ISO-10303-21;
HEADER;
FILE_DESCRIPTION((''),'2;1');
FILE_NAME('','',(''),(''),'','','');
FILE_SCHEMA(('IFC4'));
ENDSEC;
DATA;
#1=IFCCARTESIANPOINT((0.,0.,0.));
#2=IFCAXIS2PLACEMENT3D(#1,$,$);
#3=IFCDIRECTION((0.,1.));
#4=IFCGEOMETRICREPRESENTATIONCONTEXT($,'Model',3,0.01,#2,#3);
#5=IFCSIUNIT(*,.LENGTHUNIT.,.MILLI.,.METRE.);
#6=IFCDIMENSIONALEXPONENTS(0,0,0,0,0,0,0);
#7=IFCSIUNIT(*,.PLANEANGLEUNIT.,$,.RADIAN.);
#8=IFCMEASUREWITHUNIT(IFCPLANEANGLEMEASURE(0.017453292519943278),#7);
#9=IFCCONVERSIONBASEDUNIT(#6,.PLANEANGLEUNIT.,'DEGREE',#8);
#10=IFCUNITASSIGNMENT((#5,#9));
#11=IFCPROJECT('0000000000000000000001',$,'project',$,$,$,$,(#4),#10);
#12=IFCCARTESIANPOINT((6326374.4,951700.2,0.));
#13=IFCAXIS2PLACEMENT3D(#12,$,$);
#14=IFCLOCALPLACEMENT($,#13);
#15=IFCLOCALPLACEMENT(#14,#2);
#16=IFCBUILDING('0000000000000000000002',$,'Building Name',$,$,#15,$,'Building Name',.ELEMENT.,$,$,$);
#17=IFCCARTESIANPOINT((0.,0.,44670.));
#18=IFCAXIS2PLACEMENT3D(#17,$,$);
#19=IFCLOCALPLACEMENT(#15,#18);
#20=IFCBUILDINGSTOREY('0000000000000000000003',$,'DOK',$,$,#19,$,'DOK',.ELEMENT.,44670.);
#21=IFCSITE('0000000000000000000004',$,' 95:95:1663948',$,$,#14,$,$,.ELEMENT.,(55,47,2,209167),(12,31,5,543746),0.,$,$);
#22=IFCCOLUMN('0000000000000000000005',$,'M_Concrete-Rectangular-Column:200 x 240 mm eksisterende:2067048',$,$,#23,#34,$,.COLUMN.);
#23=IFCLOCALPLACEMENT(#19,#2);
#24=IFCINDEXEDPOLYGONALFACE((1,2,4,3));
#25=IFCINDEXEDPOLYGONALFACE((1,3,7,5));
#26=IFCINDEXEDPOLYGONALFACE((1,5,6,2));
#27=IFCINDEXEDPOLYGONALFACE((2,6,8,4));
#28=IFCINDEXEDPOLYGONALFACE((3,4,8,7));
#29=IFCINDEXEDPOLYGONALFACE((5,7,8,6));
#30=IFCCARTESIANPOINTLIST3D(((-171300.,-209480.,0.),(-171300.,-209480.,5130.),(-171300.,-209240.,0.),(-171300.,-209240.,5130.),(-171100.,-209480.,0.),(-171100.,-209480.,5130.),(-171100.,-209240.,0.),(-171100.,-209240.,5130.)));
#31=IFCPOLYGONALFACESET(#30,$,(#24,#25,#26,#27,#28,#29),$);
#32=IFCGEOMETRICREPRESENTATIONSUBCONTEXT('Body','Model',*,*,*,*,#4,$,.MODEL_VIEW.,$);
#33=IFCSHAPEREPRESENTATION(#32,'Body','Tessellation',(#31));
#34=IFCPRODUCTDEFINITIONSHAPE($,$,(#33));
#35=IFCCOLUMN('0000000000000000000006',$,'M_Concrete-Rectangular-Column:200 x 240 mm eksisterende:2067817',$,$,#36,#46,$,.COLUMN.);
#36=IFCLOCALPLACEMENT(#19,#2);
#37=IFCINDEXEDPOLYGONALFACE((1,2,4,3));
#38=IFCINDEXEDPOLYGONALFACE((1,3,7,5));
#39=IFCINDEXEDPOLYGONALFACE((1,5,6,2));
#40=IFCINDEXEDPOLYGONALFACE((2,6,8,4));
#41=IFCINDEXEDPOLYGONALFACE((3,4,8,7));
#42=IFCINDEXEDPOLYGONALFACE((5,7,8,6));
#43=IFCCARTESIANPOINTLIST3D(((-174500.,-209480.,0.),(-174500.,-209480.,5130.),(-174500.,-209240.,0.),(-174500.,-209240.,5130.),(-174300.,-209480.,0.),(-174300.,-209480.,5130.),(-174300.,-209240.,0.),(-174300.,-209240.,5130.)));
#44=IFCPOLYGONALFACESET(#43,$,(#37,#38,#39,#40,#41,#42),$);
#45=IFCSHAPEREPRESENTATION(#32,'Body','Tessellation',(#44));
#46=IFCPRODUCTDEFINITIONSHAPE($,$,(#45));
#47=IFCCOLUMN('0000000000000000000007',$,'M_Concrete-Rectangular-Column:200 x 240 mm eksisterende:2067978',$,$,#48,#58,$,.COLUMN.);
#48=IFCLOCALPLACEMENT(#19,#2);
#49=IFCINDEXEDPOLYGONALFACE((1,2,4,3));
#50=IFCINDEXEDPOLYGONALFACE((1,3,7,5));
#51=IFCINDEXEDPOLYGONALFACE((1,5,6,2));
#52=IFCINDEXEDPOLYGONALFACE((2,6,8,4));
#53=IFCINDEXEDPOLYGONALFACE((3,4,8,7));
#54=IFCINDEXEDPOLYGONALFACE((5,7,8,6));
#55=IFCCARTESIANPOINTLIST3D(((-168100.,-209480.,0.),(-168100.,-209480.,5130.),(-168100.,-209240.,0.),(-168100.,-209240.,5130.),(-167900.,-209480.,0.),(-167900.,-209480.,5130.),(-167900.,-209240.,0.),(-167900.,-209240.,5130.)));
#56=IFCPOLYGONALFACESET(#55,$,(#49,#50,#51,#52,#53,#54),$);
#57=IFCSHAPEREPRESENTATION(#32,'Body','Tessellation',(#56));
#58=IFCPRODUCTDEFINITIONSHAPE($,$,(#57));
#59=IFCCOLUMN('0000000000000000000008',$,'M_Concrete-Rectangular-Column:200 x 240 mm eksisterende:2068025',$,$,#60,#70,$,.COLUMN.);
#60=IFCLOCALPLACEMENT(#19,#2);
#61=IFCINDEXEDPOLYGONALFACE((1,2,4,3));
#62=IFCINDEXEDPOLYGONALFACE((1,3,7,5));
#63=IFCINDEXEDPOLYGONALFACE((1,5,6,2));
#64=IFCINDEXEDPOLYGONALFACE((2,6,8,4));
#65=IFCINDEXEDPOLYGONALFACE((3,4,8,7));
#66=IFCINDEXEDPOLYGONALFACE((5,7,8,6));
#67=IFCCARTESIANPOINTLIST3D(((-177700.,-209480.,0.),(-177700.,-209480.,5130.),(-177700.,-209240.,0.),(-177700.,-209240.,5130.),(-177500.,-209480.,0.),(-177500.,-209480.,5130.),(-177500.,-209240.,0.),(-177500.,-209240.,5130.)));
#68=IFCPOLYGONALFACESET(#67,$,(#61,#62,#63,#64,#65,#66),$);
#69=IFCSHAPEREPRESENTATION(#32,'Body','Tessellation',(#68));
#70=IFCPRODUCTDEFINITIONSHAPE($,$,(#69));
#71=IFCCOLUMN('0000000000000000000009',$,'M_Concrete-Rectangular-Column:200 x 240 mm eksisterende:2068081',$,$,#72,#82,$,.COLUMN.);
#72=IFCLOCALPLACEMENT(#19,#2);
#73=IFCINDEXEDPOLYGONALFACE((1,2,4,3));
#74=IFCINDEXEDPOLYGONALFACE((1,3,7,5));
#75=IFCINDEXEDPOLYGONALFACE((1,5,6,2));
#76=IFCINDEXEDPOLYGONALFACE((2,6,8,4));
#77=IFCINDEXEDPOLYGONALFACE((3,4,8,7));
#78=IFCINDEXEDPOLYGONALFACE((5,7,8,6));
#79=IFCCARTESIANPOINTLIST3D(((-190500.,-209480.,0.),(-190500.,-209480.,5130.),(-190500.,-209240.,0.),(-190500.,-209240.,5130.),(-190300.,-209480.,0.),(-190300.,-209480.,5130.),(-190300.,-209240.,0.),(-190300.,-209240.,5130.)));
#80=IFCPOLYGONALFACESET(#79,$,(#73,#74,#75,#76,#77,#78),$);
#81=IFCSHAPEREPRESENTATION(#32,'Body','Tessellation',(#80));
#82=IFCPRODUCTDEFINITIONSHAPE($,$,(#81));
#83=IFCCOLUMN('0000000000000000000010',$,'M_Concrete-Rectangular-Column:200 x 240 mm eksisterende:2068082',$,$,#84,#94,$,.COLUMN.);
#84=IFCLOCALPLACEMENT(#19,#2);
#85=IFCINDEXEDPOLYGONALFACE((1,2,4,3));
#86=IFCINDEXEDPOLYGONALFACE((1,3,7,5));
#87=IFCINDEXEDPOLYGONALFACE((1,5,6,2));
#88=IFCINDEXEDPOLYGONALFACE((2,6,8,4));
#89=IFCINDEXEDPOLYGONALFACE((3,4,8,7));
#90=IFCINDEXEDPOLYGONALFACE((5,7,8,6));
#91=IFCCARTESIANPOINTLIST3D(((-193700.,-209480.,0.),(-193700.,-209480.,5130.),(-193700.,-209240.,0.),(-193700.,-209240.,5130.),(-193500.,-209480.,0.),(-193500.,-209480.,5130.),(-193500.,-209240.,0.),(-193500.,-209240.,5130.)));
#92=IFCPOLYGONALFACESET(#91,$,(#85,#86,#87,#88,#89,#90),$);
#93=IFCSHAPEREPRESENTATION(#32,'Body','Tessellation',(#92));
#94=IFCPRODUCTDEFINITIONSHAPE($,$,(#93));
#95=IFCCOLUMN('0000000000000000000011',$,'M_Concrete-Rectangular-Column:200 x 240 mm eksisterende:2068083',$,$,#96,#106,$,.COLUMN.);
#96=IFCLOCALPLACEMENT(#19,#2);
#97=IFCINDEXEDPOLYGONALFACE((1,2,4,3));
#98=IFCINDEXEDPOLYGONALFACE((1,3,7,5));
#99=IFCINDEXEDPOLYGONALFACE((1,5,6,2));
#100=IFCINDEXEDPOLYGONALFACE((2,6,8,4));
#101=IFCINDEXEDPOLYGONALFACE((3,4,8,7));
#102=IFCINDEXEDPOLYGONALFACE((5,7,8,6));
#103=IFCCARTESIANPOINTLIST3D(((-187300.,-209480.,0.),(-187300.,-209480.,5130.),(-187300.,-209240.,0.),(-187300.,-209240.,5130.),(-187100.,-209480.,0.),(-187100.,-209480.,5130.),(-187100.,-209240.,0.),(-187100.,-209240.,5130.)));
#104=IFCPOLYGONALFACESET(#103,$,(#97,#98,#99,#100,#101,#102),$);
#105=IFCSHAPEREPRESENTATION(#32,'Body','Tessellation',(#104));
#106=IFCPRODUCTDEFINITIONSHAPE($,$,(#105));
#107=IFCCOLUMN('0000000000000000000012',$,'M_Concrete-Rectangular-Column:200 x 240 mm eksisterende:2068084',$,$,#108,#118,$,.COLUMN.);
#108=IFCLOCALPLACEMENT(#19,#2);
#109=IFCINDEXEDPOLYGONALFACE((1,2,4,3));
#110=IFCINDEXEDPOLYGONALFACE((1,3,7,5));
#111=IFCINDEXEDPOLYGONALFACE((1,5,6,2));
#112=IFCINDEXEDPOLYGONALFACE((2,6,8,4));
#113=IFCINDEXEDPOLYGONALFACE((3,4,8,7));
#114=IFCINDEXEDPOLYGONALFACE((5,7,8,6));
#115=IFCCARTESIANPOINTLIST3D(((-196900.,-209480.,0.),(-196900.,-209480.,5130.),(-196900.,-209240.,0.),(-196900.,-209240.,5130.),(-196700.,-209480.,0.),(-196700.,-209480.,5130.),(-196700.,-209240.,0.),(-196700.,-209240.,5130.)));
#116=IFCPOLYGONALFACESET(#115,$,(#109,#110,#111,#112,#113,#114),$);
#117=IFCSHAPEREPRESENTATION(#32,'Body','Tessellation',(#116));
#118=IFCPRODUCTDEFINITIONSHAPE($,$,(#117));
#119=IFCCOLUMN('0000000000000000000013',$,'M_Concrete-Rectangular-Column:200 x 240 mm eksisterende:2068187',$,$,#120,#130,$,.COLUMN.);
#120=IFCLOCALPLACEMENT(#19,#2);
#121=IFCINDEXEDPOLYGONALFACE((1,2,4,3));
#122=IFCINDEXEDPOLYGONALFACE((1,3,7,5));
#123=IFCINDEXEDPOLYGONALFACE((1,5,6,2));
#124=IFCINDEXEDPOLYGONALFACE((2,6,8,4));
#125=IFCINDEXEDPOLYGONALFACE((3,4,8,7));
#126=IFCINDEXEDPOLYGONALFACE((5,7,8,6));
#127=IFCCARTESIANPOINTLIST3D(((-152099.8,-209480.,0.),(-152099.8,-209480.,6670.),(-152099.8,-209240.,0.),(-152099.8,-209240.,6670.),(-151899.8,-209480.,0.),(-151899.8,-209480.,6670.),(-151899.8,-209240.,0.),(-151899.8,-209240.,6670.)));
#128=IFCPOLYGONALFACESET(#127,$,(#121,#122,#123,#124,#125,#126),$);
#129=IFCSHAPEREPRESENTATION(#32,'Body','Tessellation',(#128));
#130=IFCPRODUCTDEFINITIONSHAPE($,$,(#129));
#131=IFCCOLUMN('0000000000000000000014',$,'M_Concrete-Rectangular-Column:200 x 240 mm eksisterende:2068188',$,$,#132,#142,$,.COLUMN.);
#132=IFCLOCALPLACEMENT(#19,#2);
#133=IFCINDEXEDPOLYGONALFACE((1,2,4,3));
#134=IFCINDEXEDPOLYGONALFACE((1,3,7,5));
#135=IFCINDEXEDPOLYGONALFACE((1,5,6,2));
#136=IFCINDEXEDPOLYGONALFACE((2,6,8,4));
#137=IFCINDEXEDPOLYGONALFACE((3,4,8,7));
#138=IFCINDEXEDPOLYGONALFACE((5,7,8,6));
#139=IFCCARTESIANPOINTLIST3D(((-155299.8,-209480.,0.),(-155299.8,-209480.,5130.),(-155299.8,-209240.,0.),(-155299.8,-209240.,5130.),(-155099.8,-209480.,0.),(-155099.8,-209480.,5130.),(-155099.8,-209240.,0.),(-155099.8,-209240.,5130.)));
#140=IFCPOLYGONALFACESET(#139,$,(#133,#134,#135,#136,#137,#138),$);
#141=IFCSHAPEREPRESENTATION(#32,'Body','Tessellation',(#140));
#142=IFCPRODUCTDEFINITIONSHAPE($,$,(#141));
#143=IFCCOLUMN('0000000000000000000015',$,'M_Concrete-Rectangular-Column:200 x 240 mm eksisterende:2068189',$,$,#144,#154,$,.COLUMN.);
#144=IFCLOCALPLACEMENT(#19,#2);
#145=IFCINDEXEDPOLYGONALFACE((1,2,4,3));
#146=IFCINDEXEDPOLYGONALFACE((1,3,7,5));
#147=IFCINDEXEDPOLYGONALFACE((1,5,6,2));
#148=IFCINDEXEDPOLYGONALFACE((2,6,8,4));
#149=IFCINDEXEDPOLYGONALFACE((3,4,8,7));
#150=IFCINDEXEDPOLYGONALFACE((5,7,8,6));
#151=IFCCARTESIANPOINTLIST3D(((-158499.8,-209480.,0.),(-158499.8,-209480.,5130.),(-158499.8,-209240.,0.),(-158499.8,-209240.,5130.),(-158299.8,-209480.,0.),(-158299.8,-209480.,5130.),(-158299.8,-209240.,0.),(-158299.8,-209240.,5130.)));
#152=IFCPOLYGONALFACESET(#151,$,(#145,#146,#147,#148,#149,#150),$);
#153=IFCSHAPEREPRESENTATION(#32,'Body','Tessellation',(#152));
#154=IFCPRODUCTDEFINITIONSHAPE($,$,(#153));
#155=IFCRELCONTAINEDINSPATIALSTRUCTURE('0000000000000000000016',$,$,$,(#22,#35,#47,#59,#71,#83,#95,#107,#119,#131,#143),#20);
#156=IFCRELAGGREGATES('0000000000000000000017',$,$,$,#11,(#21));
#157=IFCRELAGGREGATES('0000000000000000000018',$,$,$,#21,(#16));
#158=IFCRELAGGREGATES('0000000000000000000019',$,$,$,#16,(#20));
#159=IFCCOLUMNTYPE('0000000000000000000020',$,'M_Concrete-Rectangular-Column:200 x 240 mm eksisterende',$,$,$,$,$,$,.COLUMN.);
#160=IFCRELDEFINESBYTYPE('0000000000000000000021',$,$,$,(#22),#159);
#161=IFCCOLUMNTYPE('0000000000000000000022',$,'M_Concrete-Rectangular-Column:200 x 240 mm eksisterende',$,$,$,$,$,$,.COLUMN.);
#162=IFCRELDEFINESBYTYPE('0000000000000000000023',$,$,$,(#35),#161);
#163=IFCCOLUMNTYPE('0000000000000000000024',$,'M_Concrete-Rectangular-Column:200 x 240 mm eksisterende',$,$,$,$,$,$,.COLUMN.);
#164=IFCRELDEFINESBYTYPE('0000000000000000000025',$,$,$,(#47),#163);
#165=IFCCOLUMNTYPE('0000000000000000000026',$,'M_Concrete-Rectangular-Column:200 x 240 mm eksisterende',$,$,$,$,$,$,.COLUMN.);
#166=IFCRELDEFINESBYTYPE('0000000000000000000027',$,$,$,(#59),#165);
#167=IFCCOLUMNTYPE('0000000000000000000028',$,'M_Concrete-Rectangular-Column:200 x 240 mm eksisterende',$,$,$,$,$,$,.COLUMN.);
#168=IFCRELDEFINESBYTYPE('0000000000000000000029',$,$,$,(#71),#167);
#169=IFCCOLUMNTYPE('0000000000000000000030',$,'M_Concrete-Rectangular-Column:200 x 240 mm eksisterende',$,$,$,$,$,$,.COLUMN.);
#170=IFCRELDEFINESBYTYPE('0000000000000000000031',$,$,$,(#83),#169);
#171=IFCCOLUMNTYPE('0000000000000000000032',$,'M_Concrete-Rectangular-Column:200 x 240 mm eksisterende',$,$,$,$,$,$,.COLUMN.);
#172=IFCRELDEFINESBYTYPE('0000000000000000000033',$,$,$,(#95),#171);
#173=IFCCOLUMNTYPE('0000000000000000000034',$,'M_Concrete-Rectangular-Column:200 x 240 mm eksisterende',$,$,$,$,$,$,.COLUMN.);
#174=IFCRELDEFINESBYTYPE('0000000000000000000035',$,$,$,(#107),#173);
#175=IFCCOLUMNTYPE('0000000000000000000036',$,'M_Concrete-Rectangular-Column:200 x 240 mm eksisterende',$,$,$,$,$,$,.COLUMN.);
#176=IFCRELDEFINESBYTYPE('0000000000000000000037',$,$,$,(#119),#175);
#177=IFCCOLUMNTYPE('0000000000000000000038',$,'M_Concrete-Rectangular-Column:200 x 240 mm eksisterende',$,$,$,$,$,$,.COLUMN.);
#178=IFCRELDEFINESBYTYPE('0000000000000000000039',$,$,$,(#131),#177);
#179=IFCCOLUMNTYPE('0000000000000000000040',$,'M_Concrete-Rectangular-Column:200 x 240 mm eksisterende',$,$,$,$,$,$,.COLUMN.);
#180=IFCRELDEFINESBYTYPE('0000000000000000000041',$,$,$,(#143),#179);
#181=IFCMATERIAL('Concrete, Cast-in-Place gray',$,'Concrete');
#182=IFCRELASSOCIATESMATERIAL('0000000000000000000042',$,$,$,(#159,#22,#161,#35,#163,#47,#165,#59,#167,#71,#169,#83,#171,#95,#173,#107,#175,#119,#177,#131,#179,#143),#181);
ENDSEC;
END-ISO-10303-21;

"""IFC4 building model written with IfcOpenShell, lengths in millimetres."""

from ifc_helpers import new_model, entity, si_unit, converted_unit, direction, frame, origin, place, context, subcontext, project, spatial, indexed_curve, outline, extrude, source, transform, mapped, material, type_object, type_shapes, element, save


model = new_model("IFC4")

# Units and contexts
model_context = context("Model", 3, precision=0.01, world=origin(), true_north=direction((0.0, 1.0)))
body_context = subcontext(model_context, "Body", "Model", "MODEL_VIEW")
ifc_project = project(units=[si_unit("LENGTHUNIT", "METRE", prefix="MILLI"), converted_unit("PLANEANGLEUNIT", "DEGREE", entity("IfcPlaneAngleMeasure", 0.017453292519943278), si_unit("PLANEANGLEUNIT", "RADIAN"), dimensions=[0, 0, 0, 0, 0, 0, 0])], contexts=[model_context])

# Site, building, storey
site_placement = place(None, frame((6326374.4, 951700.2, 0.0)))
site = spatial("IfcSite", under=ifc_project, at=site_placement, Name=" 95:95:1663948", CompositionType="ELEMENT", RefLatitude=(55, 47, 2, 209167), RefLongitude=(12, 31, 5, 543746), RefElevation=0.0)
building_placement = place(site_placement, origin())
building = spatial("IfcBuilding", under=site, at=building_placement, Name="Building Name", LongName="Building Name", CompositionType="ELEMENT")
storey_placement = place(building_placement, frame((0.0, 0.0, 44670.0)))
storey = spatial("IfcBuildingStorey", under=building, at=storey_placement, Name="DOK", LongName="DOK", CompositionType="ELEMENT", Elevation=44670.0)

# Columns
ifc_material_1 = material(Name="Concrete, Cast-in-Place gray", Category="Concrete")
column_type_1 = type_object("IfcColumnType", Name="M_Concrete-Rectangular-Column:200 x 240 mm eksisterende", PredefinedType="COLUMN", material=ifc_material_1)
shared_shape_1 = source(origin(), body_context, "Body", "SweptSolid", [
    extrude(outline(indexed_curve([(-100.0, -120.0), (100.0, -120.0), (100.0, 120.0), (-100.0, 120.0), (-100.0, -120.0)], self_intersect=False)), frame((-171200.0, -209360.0, 44670.0), z_axis=(0.0, 0.0, 1.0), x_axis=(-1.0, 0.0, 0.0)), (0.0, 0.0, 1.0), 5130.0),
])
type_shapes(column_type_1, [shared_shape_1])
column_1_placement = place(storey_placement, frame((0.0, 0.0, -44670.0)))
element("IfcColumn", 1, at=column_1_placement, inside=storey, type_object=column_type_1, material=ifc_material_1, Name="M_Concrete-Rectangular-Column:200 x 240 mm eksisterende:2067048", PredefinedType="COLUMN", context=body_context, shape_type="MappedRepresentation", body=[
    mapped(shared_shape_1, transform((0.0, 0.0, 0.0), scale=1.0)),
])
column_type_2 = type_object("IfcColumnType", Name="M_Concrete-Rectangular-Column:200 x 240 mm eksisterende", PredefinedType="COLUMN", material=ifc_material_1)
shared_shape_2 = source(origin(), body_context, "Body", "SweptSolid", [
    extrude(outline(indexed_curve([(-100.0, -120.0), (100.0, -120.0), (100.0, 120.0), (-100.0, 120.0), (-100.0, -120.0)], self_intersect=False)), frame((-174400.0, -209360.0, 44670.0), z_axis=(0.0, 0.0, 1.0), x_axis=(-1.0, 0.0, 0.0)), (0.0, 0.0, 1.0), 5130.0),
])
type_shapes(column_type_2, [shared_shape_2])
column_2_placement = place(storey_placement, frame((0.0, 0.0, -44670.0)))
element("IfcColumn", 2, at=column_2_placement, inside=storey, type_object=column_type_2, material=ifc_material_1, Name="M_Concrete-Rectangular-Column:200 x 240 mm eksisterende:2067817", PredefinedType="COLUMN", context=body_context, shape_type="MappedRepresentation", body=[
    mapped(shared_shape_2, transform((0.0, 0.0, 0.0), scale=1.0)),
])
column_type_3 = type_object("IfcColumnType", Name="M_Concrete-Rectangular-Column:200 x 240 mm eksisterende", PredefinedType="COLUMN", material=ifc_material_1)
shared_shape_3 = source(origin(), body_context, "Body", "SweptSolid", [
    extrude(outline(indexed_curve([(-100.0, -120.0), (100.0, -120.0), (100.0, 120.0), (-100.0, 120.0), (-100.0, -120.0)], self_intersect=False)), frame((-168000.0, -209360.0, 44670.0), z_axis=(0.0, 0.0, 1.0), x_axis=(-1.0, 0.0, 0.0)), (0.0, 0.0, 1.0), 5130.0),
])
type_shapes(column_type_3, [shared_shape_3])
column_3_placement = place(storey_placement, frame((0.0, 0.0, -44670.0)))
element("IfcColumn", 3, at=column_3_placement, inside=storey, type_object=column_type_3, material=ifc_material_1, Name="M_Concrete-Rectangular-Column:200 x 240 mm eksisterende:2067978", PredefinedType="COLUMN", context=body_context, shape_type="MappedRepresentation", body=[
    mapped(shared_shape_3, transform((0.0, 0.0, 0.0), scale=1.0)),
])
column_type_4 = type_object("IfcColumnType", Name="M_Concrete-Rectangular-Column:200 x 240 mm eksisterende", PredefinedType="COLUMN", material=ifc_material_1)
shared_shape_4 = source(origin(), body_context, "Body", "SweptSolid", [
    extrude(outline(indexed_curve([(-100.0, -120.0), (100.0, -120.0), (100.0, 120.0), (-100.0, 120.0), (-100.0, -120.0)], self_intersect=False)), frame((-177600.0, -209360.0, 44670.0), z_axis=(0.0, 0.0, 1.0), x_axis=(-1.0, 0.0, 0.0)), (0.0, 0.0, 1.0), 5130.0),
])
type_shapes(column_type_4, [shared_shape_4])
column_4_placement = place(storey_placement, frame((0.0, 0.0, -44670.0)))
element("IfcColumn", 4, at=column_4_placement, inside=storey, type_object=column_type_4, material=ifc_material_1, Name="M_Concrete-Rectangular-Column:200 x 240 mm eksisterende:2068025", PredefinedType="COLUMN", context=body_context, shape_type="MappedRepresentation", body=[
    mapped(shared_shape_4, transform((0.0, 0.0, 0.0), scale=1.0)),
])
column_type_5 = type_object("IfcColumnType", Name="M_Concrete-Rectangular-Column:200 x 240 mm eksisterende", PredefinedType="COLUMN", material=ifc_material_1)
shared_shape_5 = source(origin(), body_context, "Body", "SweptSolid", [
    extrude(outline(indexed_curve([(-100.0, -120.0), (100.0, -120.0), (100.0, 120.0), (-100.0, 120.0), (-100.0, -120.0)], self_intersect=False)), frame((-190400.0, -209360.0, 44670.0), z_axis=(0.0, 0.0, 1.0), x_axis=(-1.0, 0.0, 0.0)), (0.0, 0.0, 1.0), 5130.0),
])
type_shapes(column_type_5, [shared_shape_5])
column_5_placement = place(storey_placement, frame((0.0, 0.0, -44670.0)))
element("IfcColumn", 5, at=column_5_placement, inside=storey, type_object=column_type_5, material=ifc_material_1, Name="M_Concrete-Rectangular-Column:200 x 240 mm eksisterende:2068081", PredefinedType="COLUMN", context=body_context, shape_type="MappedRepresentation", body=[
    mapped(shared_shape_5, transform((0.0, 0.0, 0.0), scale=1.0)),
])
column_type_6 = type_object("IfcColumnType", Name="M_Concrete-Rectangular-Column:200 x 240 mm eksisterende", PredefinedType="COLUMN", material=ifc_material_1)
shared_shape_6 = source(origin(), body_context, "Body", "SweptSolid", [
    extrude(outline(indexed_curve([(-100.0, -120.0), (100.0, -120.0), (100.0, 120.0), (-100.0, 120.0), (-100.0, -120.0)], self_intersect=False)), frame((-193600.0, -209360.0, 44670.0), z_axis=(0.0, 0.0, 1.0), x_axis=(-1.0, 0.0, 0.0)), (0.0, 0.0, 1.0), 5130.0),
])
type_shapes(column_type_6, [shared_shape_6])
column_6_placement = place(storey_placement, frame((0.0, 0.0, -44670.0)))
element("IfcColumn", 6, at=column_6_placement, inside=storey, type_object=column_type_6, material=ifc_material_1, Name="M_Concrete-Rectangular-Column:200 x 240 mm eksisterende:2068082", PredefinedType="COLUMN", context=body_context, shape_type="MappedRepresentation", body=[
    mapped(shared_shape_6, transform((0.0, 0.0, 0.0), scale=1.0)),
])
column_type_7 = type_object("IfcColumnType", Name="M_Concrete-Rectangular-Column:200 x 240 mm eksisterende", PredefinedType="COLUMN", material=ifc_material_1)
shared_shape_7 = source(origin(), body_context, "Body", "SweptSolid", [
    extrude(outline(indexed_curve([(-100.0, -120.0), (100.0, -120.0), (100.0, 120.0), (-100.0, 120.0), (-100.0, -120.0)], self_intersect=False)), frame((-187200.0, -209360.0, 44670.0), z_axis=(0.0, 0.0, 1.0), x_axis=(-1.0, 0.0, 0.0)), (0.0, 0.0, 1.0), 5130.0),
])
type_shapes(column_type_7, [shared_shape_7])
column_7_placement = place(storey_placement, frame((0.0, 0.0, -44670.0)))
element("IfcColumn", 7, at=column_7_placement, inside=storey, type_object=column_type_7, material=ifc_material_1, Name="M_Concrete-Rectangular-Column:200 x 240 mm eksisterende:2068083", PredefinedType="COLUMN", context=body_context, shape_type="MappedRepresentation", body=[
    mapped(shared_shape_7, transform((0.0, 0.0, 0.0), scale=1.0)),
])
column_type_8 = type_object("IfcColumnType", Name="M_Concrete-Rectangular-Column:200 x 240 mm eksisterende", PredefinedType="COLUMN", material=ifc_material_1)
shared_shape_8 = source(origin(), body_context, "Body", "SweptSolid", [
    extrude(outline(indexed_curve([(-100.0, -120.0), (100.0, -120.0), (100.0, 120.0), (-100.0, 120.0), (-100.0, -120.0)], self_intersect=False)), frame((-196800.0, -209360.0, 44670.0), z_axis=(0.0, 0.0, 1.0), x_axis=(-1.0, 0.0, 0.0)), (0.0, 0.0, 1.0), 5130.0),
])
type_shapes(column_type_8, [shared_shape_8])
column_8_placement = place(storey_placement, frame((0.0, 0.0, -44670.0)))
element("IfcColumn", 8, at=column_8_placement, inside=storey, type_object=column_type_8, material=ifc_material_1, Name="M_Concrete-Rectangular-Column:200 x 240 mm eksisterende:2068084", PredefinedType="COLUMN", context=body_context, shape_type="MappedRepresentation", body=[
    mapped(shared_shape_8, transform((0.0, 0.0, 0.0), scale=1.0)),
])
column_type_9 = type_object("IfcColumnType", Name="M_Concrete-Rectangular-Column:200 x 240 mm eksisterende", PredefinedType="COLUMN", material=ifc_material_1)
shared_shape_9 = source(origin(), body_context, "Body", "SweptSolid", [
    extrude(outline(indexed_curve([(-100.0, -120.0), (100.0, -120.0), (100.0, 120.0), (-100.0, 120.0), (-100.0, -120.0)], self_intersect=False)), frame((-151999.8, -209360.0, 44670.0), z_axis=(0.0, 0.0, 1.0), x_axis=(-1.0, 0.0, 0.0)), (0.0, 0.0, 1.0), 6670.0),
])
type_shapes(column_type_9, [shared_shape_9])
column_9_placement = place(storey_placement, frame((0.0, 0.0, -44670.0)))
element("IfcColumn", 9, at=column_9_placement, inside=storey, type_object=column_type_9, material=ifc_material_1, Name="M_Concrete-Rectangular-Column:200 x 240 mm eksisterende:2068187", PredefinedType="COLUMN", context=body_context, shape_type="MappedRepresentation", body=[
    mapped(shared_shape_9, transform((0.0, 0.0, 0.0), scale=1.0)),
])
column_type_10 = type_object("IfcColumnType", Name="M_Concrete-Rectangular-Column:200 x 240 mm eksisterende", PredefinedType="COLUMN", material=ifc_material_1)
shared_shape_10 = source(origin(), body_context, "Body", "SweptSolid", [
    extrude(outline(indexed_curve([(-100.0, -120.0), (100.0, -120.0), (100.0, 120.0), (-100.0, 120.0), (-100.0, -120.0)], self_intersect=False)), frame((-155199.8, -209360.0, 44670.0), z_axis=(0.0, 0.0, 1.0), x_axis=(-1.0, 0.0, 0.0)), (0.0, 0.0, 1.0), 5130.0),
])
type_shapes(column_type_10, [shared_shape_10])
column_10_placement = place(storey_placement, frame((0.0, 0.0, -44670.0)))
element("IfcColumn", 10, at=column_10_placement, inside=storey, type_object=column_type_10, material=ifc_material_1, Name="M_Concrete-Rectangular-Column:200 x 240 mm eksisterende:2068188", PredefinedType="COLUMN", context=body_context, shape_type="MappedRepresentation", body=[
    mapped(shared_shape_10, transform((0.0, 0.0, 0.0), scale=1.0)),
])
column_type_11 = type_object("IfcColumnType", Name="M_Concrete-Rectangular-Column:200 x 240 mm eksisterende", PredefinedType="COLUMN", material=ifc_material_1)
shared_shape_11 = source(origin(), body_context, "Body", "SweptSolid", [
    extrude(outline(indexed_curve([(-100.0, -120.0), (100.0, -120.0), (100.0, 120.0), (-100.0, 120.0), (-100.0, -120.0)], self_intersect=False)), frame((-158399.8, -209360.0, 44670.0), z_axis=(0.0, 0.0, 1.0), x_axis=(-1.0, 0.0, 0.0)), (0.0, 0.0, 1.0), 5130.0),
])
type_shapes(column_type_11, [shared_shape_11])
column_11_placement = place(storey_placement, frame((0.0, 0.0, -44670.0)))
element("IfcColumn", 11, at=column_11_placement, inside=storey, type_object=column_type_11, material=ifc_material_1, Name="M_Concrete-Rectangular-Column:200 x 240 mm eksisterende:2068189", PredefinedType="COLUMN", context=body_context, shape_type="MappedRepresentation", body=[
    mapped(shared_shape_11, transform((0.0, 0.0, 0.0), scale=1.0)),
])

save(model, "model.ifc")
